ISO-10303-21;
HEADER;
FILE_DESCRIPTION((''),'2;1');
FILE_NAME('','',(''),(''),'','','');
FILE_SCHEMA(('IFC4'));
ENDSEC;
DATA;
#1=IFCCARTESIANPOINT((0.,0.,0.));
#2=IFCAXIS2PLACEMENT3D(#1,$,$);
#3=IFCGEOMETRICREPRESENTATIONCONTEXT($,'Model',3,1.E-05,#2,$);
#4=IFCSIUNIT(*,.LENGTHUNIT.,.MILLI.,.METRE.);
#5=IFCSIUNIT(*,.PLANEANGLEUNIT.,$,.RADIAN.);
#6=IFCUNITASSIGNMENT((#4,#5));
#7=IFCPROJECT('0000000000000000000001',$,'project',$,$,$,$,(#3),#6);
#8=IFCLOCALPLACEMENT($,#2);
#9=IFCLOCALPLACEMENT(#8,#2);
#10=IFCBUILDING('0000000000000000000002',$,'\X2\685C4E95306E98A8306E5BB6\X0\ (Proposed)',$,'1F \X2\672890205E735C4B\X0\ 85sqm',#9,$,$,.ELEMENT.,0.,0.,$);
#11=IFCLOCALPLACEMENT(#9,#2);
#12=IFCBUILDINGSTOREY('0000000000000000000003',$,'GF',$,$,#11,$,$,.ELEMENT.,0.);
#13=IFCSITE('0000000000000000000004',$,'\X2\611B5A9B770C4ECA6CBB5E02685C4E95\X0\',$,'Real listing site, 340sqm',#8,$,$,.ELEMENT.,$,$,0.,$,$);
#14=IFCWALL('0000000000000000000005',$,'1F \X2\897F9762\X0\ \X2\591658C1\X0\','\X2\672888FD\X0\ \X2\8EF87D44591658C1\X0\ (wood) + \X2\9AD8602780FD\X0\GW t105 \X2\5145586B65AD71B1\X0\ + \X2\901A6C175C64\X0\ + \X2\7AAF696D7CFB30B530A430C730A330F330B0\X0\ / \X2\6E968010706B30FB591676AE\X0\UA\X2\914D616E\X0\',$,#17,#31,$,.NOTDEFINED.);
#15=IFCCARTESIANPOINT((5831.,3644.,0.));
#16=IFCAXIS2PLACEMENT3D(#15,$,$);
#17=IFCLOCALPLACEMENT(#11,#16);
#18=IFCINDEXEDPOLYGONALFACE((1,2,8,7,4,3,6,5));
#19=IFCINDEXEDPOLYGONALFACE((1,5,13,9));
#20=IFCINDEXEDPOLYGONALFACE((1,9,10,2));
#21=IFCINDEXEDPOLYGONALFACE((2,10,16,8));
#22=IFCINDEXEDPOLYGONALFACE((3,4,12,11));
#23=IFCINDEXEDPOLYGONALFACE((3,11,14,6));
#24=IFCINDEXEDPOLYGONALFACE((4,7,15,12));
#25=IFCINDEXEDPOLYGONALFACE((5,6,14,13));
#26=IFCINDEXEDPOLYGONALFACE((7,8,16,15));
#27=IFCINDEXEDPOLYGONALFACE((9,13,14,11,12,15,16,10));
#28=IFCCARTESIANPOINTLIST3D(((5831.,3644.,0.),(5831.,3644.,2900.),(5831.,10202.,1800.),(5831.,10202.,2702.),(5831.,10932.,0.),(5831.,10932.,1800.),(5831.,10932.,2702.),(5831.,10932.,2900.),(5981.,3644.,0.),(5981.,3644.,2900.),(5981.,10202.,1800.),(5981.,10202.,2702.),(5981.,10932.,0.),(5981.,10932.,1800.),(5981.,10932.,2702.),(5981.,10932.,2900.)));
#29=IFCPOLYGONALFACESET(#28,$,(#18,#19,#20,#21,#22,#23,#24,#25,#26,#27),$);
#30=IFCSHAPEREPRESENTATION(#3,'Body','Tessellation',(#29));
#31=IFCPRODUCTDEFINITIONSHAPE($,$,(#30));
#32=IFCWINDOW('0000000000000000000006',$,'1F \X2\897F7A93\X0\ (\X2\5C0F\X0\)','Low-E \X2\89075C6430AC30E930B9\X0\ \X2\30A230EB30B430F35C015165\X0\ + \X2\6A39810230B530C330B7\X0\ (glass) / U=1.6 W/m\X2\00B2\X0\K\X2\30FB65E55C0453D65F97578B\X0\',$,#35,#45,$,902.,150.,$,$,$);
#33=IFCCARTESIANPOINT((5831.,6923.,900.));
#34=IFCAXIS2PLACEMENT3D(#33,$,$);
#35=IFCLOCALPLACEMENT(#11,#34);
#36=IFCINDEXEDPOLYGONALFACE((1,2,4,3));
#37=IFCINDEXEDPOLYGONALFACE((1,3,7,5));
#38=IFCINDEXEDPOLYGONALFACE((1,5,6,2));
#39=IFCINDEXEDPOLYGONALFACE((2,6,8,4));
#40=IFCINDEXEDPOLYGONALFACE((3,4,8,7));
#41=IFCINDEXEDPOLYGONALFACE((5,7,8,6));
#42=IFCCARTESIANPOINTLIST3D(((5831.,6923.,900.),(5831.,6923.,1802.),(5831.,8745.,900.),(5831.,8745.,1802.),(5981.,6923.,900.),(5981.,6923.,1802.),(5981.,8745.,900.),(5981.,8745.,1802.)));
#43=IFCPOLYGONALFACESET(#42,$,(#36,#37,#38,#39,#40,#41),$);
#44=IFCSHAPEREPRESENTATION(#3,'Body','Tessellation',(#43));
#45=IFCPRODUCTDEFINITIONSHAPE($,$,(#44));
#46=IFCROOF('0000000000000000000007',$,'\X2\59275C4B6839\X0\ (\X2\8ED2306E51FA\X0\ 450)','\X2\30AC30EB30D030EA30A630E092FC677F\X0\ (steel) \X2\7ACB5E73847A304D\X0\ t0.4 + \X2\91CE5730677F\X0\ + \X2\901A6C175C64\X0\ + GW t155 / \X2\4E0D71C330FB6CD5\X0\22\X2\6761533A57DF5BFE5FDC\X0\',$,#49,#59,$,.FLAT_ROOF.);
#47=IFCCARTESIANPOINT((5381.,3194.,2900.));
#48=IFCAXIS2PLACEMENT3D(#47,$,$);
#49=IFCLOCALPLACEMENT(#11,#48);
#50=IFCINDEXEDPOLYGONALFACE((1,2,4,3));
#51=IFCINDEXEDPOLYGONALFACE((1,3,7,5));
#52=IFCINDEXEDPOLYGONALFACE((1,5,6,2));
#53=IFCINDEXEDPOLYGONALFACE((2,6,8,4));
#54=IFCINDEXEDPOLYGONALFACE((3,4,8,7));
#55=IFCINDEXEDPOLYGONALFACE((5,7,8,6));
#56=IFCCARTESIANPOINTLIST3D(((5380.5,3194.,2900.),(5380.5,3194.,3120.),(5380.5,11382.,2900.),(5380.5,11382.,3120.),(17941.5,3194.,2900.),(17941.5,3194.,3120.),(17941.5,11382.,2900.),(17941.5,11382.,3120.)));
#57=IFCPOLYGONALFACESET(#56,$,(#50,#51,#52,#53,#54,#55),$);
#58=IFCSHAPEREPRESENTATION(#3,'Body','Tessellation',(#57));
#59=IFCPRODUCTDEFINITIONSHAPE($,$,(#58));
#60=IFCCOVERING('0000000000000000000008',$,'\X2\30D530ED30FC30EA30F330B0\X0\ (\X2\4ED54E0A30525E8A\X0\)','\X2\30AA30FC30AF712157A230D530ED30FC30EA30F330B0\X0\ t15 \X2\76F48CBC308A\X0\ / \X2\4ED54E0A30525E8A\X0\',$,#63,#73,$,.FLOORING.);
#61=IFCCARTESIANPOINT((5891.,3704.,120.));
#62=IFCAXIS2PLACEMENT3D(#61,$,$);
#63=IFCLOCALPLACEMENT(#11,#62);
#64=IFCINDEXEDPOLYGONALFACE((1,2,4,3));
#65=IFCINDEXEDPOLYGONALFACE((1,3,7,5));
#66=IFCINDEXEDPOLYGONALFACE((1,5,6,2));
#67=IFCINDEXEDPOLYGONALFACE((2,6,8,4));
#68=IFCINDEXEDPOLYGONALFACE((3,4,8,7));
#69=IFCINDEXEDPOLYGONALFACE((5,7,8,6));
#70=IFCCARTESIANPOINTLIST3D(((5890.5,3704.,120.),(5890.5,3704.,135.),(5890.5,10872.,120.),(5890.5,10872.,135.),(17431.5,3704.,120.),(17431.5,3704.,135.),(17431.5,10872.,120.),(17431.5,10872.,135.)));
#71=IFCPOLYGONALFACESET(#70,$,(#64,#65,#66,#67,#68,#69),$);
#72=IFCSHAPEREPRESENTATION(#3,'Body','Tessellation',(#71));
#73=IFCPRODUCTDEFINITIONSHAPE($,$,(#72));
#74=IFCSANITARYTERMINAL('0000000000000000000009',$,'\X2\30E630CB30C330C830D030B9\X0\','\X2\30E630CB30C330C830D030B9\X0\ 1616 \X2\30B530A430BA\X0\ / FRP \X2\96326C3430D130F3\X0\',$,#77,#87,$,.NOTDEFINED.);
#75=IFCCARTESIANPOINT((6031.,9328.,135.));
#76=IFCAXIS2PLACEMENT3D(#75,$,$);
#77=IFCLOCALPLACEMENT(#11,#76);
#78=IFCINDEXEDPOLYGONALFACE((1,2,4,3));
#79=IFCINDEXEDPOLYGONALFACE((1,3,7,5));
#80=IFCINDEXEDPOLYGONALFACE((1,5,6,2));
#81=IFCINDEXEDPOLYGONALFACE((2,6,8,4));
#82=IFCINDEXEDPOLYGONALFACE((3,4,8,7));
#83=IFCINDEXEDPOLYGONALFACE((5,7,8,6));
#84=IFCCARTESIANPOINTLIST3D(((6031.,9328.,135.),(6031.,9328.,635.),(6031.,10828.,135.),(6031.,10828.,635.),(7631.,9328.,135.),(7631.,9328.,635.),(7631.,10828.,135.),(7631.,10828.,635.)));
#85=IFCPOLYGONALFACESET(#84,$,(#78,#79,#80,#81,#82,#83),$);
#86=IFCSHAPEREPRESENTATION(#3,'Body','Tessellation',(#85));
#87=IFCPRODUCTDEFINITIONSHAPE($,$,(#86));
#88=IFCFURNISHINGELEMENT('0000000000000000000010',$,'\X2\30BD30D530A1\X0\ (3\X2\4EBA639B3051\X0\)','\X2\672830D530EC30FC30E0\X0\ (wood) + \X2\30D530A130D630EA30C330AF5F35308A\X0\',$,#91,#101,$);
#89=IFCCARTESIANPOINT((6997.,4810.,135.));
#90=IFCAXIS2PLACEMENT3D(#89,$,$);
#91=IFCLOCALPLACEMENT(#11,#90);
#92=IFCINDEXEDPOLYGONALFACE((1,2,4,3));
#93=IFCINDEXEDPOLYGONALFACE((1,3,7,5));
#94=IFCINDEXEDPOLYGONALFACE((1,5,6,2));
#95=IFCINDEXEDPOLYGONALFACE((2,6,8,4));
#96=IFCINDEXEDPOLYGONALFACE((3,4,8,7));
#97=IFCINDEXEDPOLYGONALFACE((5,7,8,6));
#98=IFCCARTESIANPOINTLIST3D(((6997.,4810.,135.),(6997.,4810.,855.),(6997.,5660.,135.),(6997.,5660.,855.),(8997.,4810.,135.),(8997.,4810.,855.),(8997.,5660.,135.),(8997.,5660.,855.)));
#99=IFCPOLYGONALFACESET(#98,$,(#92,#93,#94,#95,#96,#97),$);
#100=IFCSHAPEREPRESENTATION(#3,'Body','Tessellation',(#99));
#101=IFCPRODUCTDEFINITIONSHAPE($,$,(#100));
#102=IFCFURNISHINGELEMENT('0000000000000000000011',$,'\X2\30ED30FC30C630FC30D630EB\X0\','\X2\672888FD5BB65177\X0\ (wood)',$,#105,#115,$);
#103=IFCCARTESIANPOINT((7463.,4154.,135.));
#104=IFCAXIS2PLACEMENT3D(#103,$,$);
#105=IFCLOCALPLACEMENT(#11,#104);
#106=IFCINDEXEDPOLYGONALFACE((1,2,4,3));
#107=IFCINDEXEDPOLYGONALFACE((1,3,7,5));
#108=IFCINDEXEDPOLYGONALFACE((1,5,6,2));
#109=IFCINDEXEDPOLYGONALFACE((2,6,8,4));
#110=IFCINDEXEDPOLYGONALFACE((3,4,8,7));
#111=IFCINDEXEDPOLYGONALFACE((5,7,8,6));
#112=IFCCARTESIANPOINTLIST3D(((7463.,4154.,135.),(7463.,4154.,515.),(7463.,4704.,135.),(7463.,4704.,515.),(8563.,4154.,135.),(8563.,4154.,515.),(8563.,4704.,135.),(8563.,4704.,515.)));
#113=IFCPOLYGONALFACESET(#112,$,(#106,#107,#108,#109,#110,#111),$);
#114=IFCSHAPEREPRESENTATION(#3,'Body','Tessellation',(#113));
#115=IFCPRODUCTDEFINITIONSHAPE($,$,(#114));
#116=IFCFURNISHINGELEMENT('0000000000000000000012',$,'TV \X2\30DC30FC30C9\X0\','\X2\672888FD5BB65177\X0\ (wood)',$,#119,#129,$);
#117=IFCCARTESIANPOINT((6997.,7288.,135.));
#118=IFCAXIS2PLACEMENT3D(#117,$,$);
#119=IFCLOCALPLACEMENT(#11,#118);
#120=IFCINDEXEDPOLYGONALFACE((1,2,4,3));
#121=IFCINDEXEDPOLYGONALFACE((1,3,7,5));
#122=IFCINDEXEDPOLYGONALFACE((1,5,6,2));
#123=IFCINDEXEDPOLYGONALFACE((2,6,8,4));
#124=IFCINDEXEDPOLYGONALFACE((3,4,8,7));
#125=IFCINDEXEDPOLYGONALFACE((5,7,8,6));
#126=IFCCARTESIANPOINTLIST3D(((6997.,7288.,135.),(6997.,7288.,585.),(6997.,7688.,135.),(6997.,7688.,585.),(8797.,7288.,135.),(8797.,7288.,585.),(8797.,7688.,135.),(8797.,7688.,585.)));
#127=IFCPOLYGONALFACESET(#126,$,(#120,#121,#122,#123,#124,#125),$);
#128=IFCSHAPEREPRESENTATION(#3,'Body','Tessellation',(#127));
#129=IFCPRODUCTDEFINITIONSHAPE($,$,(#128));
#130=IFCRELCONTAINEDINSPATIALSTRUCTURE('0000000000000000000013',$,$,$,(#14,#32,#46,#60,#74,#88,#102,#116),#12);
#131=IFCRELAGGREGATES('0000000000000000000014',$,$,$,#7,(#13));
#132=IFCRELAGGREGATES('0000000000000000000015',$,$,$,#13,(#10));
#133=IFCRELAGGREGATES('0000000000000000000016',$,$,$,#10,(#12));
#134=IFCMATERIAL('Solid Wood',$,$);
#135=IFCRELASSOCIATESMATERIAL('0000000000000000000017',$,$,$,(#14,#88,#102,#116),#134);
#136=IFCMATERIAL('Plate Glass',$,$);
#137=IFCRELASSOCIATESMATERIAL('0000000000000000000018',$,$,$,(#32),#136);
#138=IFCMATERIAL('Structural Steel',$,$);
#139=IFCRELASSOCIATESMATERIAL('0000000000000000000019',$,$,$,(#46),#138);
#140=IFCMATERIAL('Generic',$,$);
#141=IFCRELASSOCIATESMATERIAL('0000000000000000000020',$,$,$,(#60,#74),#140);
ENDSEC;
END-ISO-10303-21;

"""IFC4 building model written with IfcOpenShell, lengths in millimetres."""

from ifc_helpers import new_model, si_unit, frame, frame_2d, origin, place, context, project, spatial, rectangle, extrude, material, element, fill, save


model = new_model("IFC4")

# Units and contexts
model_context = context("Model", 3, precision=1e-05, world=origin())
ifc_project = project(units=[si_unit("LENGTHUNIT", "METRE", prefix="MILLI"), si_unit("PLANEANGLEUNIT", "RADIAN")], contexts=[model_context])

# Site, building, storey
site_placement = place(None, origin())
site = spatial("IfcSite", under=ifc_project, at=site_placement, Name="愛媛県今治市桜井", ObjectType="Real listing site, 340sqm", CompositionType="ELEMENT", RefElevation=0.0)
building_placement = place(site_placement, origin())
building = spatial("IfcBuilding", under=site, at=building_placement, Name="桜井の風の家 (Proposed)", ObjectType="1F 木造平屋 85sqm", CompositionType="ELEMENT", ElevationOfRefHeight=0.0, ElevationOfTerrain=0.0)
storey_placement = place(building_placement, origin())
storey = spatial("IfcBuildingStorey", under=building, at=storey_placement, Name="GF", CompositionType="ELEMENT", Elevation=0.0)

# Shared definitions
ifc_material_1 = material(Name="Solid Wood")

# Shared definitions
ifc_material_2 = material(Name="Plate Glass")

# Wall, opening, window
wall_1_placement = place(storey_placement, frame((5831.0, 3644.0, 0.0)))
wall_1 = element("IfcWall", 1, at=wall_1_placement, inside=storey, material=ifc_material_1, Name="1F 西面 外壁", Description="木製 軸組外壁 (wood) + 高性能GW t105 充填断熱 + 通気層 + 窯業系サイディング / 準耐火・外皮UA配慮", PredefinedType="NOTDEFINED", context=model_context, shape_type="SweptSolid", body=[
    extrude(rectangle(XDim=150.0, YDim=7288.0, at=frame_2d((75.0, 3644.0))), frame((5831.0, 3644.0, 0.0)), (0.0, 0.0, 1.0), 2900.0),
])
opening_1_placement = place(storey_placement, frame((5831.0, 6923.0, 900.0)))
opening_1 = element("IfcOpeningElement", 2, at=opening_1_placement, cuts=wall_1, PredefinedType="NOTDEFINED", context=model_context, shape_type="SweptSolid", body=[
    extrude(rectangle(XDim=150.0, YDim=1822.0, at=frame_2d((75.0, 911.0))), frame((5831.0, 6923.0, 900.0)), (0.0, 0.0, 1.0), 902.0),
])
window_1_placement = place(storey_placement, frame((5831.0, 6923.0, 900.0)))
window_1 = element("IfcWindow", 3, at=window_1_placement, inside=storey, material=ifc_material_2, Name="1F 西窓 (小)", Description="Low-E 複層ガラス アルゴン封入 + 樹脂サッシ (glass) / U=1.6 W/m²K・日射取得型", OverallHeight=902.0, OverallWidth=150.0, context=model_context, shape_type="SweptSolid", body=[
    extrude(rectangle(XDim=150.0, YDim=1822.0, at=frame_2d((75.0, 911.0))), frame((5831.0, 6923.0, 900.0)), (0.0, 0.0, 1.0), 902.0),
])
fill(opening_1, window_1)

# Roof
ifc_material_3 = material(Name="Structural Steel")
roof_placement = place(storey_placement, frame((5381.0, 3194.0, 2900.0)))
element("IfcRoof", 4, at=roof_placement, inside=storey, material=ifc_material_3, Name="大屋根 (軒の出 450)", Description="ガルバリウム鋼板 (steel) 立平葺き t0.4 + 野地板 + 通気層 + GW t155 / 不燃・法22条区域対応", PredefinedType="FLAT_ROOF", context=model_context, shape_type="SweptSolid", body=[
    extrude(rectangle(XDim=12561.0, YDim=8188.0, at=frame_2d((6280.0, 4094.0))), frame((5381.0, 3194.0, 2900.0)), (0.0, 0.0, 1.0), 220.0),
])

# Covering
ifc_material_4 = material(Name="Generic")
covering_placement = place(storey_placement, frame((5891.0, 3704.0, 120.0)))
element("IfcCovering", 5, at=covering_placement, inside=storey, material=ifc_material_4, Name="フローリング (仕上げ床)", Description="オーク無垢フローリング t15 直貼り / 仕上げ床", PredefinedType="FLOORING", context=model_context, shape_type="SweptSolid", body=[
    extrude(rectangle(XDim=11541.0, YDim=7168.0, at=frame_2d((5770.0, 3584.0))), frame((5891.0, 3704.0, 120.0)), (0.0, 0.0, 1.0), 15.0),
])

# Sanitary terminal
sanitary_terminal_placement = place(storey_placement, frame((6031.0, 9328.0, 135.0)))
element("IfcSanitaryTerminal", 6, at=sanitary_terminal_placement, inside=storey, material=ifc_material_4, Name="ユニットバス", Description="ユニットバス 1616 サイズ / FRP 防水パン", PredefinedType="NOTDEFINED", context=model_context, shape_type="SweptSolid", body=[
    extrude(rectangle(XDim=1600.0, YDim=1500.0, at=frame_2d((800.0, 750.0))), frame((6031.0, 9328.0, 135.0)), (0.0, 0.0, 1.0), 500.0),
])

# Furnishing elements
furnishing_1_placement = place(storey_placement, frame((6997.0, 4810.0, 135.0)))
element("IfcFurnishingElement", 7, at=furnishing_1_placement, inside=storey, material=ifc_material_1, Name="ソファ (3人掛け)", Description="木フレーム (wood) + ファブリック張り", context=model_context, shape_type="SweptSolid", body=[
    extrude(rectangle(XDim=2000.0, YDim=850.0, at=frame_2d((1000.0, 425.0))), frame((6997.0, 4810.0, 135.0)), (0.0, 0.0, 1.0), 720.0),
])
furnishing_2_placement = place(storey_placement, frame((7463.0, 4154.0, 135.0)))
element("IfcFurnishingElement", 8, at=furnishing_2_placement, inside=storey, material=ifc_material_1, Name="ローテーブル", Description="木製家具 (wood)", context=model_context, shape_type="SweptSolid", body=[
    extrude(rectangle(XDim=1100.0, YDim=550.0, at=frame_2d((550.0, 275.0))), frame((7463.0, 4154.0, 135.0)), (0.0, 0.0, 1.0), 380.0),
])
furnishing_3_placement = place(storey_placement, frame((6997.0, 7288.0, 135.0)))
element("IfcFurnishingElement", 9, at=furnishing_3_placement, inside=storey, material=ifc_material_1, Name="TV ボード", Description="木製家具 (wood)", context=model_context, shape_type="SweptSolid", body=[
    extrude(rectangle(XDim=1800.0, YDim=400.0, at=frame_2d((900.0, 200.0))), frame((6997.0, 7288.0, 135.0)), (0.0, 0.0, 1.0), 450.0),
])

save(model, "model.ifc")
